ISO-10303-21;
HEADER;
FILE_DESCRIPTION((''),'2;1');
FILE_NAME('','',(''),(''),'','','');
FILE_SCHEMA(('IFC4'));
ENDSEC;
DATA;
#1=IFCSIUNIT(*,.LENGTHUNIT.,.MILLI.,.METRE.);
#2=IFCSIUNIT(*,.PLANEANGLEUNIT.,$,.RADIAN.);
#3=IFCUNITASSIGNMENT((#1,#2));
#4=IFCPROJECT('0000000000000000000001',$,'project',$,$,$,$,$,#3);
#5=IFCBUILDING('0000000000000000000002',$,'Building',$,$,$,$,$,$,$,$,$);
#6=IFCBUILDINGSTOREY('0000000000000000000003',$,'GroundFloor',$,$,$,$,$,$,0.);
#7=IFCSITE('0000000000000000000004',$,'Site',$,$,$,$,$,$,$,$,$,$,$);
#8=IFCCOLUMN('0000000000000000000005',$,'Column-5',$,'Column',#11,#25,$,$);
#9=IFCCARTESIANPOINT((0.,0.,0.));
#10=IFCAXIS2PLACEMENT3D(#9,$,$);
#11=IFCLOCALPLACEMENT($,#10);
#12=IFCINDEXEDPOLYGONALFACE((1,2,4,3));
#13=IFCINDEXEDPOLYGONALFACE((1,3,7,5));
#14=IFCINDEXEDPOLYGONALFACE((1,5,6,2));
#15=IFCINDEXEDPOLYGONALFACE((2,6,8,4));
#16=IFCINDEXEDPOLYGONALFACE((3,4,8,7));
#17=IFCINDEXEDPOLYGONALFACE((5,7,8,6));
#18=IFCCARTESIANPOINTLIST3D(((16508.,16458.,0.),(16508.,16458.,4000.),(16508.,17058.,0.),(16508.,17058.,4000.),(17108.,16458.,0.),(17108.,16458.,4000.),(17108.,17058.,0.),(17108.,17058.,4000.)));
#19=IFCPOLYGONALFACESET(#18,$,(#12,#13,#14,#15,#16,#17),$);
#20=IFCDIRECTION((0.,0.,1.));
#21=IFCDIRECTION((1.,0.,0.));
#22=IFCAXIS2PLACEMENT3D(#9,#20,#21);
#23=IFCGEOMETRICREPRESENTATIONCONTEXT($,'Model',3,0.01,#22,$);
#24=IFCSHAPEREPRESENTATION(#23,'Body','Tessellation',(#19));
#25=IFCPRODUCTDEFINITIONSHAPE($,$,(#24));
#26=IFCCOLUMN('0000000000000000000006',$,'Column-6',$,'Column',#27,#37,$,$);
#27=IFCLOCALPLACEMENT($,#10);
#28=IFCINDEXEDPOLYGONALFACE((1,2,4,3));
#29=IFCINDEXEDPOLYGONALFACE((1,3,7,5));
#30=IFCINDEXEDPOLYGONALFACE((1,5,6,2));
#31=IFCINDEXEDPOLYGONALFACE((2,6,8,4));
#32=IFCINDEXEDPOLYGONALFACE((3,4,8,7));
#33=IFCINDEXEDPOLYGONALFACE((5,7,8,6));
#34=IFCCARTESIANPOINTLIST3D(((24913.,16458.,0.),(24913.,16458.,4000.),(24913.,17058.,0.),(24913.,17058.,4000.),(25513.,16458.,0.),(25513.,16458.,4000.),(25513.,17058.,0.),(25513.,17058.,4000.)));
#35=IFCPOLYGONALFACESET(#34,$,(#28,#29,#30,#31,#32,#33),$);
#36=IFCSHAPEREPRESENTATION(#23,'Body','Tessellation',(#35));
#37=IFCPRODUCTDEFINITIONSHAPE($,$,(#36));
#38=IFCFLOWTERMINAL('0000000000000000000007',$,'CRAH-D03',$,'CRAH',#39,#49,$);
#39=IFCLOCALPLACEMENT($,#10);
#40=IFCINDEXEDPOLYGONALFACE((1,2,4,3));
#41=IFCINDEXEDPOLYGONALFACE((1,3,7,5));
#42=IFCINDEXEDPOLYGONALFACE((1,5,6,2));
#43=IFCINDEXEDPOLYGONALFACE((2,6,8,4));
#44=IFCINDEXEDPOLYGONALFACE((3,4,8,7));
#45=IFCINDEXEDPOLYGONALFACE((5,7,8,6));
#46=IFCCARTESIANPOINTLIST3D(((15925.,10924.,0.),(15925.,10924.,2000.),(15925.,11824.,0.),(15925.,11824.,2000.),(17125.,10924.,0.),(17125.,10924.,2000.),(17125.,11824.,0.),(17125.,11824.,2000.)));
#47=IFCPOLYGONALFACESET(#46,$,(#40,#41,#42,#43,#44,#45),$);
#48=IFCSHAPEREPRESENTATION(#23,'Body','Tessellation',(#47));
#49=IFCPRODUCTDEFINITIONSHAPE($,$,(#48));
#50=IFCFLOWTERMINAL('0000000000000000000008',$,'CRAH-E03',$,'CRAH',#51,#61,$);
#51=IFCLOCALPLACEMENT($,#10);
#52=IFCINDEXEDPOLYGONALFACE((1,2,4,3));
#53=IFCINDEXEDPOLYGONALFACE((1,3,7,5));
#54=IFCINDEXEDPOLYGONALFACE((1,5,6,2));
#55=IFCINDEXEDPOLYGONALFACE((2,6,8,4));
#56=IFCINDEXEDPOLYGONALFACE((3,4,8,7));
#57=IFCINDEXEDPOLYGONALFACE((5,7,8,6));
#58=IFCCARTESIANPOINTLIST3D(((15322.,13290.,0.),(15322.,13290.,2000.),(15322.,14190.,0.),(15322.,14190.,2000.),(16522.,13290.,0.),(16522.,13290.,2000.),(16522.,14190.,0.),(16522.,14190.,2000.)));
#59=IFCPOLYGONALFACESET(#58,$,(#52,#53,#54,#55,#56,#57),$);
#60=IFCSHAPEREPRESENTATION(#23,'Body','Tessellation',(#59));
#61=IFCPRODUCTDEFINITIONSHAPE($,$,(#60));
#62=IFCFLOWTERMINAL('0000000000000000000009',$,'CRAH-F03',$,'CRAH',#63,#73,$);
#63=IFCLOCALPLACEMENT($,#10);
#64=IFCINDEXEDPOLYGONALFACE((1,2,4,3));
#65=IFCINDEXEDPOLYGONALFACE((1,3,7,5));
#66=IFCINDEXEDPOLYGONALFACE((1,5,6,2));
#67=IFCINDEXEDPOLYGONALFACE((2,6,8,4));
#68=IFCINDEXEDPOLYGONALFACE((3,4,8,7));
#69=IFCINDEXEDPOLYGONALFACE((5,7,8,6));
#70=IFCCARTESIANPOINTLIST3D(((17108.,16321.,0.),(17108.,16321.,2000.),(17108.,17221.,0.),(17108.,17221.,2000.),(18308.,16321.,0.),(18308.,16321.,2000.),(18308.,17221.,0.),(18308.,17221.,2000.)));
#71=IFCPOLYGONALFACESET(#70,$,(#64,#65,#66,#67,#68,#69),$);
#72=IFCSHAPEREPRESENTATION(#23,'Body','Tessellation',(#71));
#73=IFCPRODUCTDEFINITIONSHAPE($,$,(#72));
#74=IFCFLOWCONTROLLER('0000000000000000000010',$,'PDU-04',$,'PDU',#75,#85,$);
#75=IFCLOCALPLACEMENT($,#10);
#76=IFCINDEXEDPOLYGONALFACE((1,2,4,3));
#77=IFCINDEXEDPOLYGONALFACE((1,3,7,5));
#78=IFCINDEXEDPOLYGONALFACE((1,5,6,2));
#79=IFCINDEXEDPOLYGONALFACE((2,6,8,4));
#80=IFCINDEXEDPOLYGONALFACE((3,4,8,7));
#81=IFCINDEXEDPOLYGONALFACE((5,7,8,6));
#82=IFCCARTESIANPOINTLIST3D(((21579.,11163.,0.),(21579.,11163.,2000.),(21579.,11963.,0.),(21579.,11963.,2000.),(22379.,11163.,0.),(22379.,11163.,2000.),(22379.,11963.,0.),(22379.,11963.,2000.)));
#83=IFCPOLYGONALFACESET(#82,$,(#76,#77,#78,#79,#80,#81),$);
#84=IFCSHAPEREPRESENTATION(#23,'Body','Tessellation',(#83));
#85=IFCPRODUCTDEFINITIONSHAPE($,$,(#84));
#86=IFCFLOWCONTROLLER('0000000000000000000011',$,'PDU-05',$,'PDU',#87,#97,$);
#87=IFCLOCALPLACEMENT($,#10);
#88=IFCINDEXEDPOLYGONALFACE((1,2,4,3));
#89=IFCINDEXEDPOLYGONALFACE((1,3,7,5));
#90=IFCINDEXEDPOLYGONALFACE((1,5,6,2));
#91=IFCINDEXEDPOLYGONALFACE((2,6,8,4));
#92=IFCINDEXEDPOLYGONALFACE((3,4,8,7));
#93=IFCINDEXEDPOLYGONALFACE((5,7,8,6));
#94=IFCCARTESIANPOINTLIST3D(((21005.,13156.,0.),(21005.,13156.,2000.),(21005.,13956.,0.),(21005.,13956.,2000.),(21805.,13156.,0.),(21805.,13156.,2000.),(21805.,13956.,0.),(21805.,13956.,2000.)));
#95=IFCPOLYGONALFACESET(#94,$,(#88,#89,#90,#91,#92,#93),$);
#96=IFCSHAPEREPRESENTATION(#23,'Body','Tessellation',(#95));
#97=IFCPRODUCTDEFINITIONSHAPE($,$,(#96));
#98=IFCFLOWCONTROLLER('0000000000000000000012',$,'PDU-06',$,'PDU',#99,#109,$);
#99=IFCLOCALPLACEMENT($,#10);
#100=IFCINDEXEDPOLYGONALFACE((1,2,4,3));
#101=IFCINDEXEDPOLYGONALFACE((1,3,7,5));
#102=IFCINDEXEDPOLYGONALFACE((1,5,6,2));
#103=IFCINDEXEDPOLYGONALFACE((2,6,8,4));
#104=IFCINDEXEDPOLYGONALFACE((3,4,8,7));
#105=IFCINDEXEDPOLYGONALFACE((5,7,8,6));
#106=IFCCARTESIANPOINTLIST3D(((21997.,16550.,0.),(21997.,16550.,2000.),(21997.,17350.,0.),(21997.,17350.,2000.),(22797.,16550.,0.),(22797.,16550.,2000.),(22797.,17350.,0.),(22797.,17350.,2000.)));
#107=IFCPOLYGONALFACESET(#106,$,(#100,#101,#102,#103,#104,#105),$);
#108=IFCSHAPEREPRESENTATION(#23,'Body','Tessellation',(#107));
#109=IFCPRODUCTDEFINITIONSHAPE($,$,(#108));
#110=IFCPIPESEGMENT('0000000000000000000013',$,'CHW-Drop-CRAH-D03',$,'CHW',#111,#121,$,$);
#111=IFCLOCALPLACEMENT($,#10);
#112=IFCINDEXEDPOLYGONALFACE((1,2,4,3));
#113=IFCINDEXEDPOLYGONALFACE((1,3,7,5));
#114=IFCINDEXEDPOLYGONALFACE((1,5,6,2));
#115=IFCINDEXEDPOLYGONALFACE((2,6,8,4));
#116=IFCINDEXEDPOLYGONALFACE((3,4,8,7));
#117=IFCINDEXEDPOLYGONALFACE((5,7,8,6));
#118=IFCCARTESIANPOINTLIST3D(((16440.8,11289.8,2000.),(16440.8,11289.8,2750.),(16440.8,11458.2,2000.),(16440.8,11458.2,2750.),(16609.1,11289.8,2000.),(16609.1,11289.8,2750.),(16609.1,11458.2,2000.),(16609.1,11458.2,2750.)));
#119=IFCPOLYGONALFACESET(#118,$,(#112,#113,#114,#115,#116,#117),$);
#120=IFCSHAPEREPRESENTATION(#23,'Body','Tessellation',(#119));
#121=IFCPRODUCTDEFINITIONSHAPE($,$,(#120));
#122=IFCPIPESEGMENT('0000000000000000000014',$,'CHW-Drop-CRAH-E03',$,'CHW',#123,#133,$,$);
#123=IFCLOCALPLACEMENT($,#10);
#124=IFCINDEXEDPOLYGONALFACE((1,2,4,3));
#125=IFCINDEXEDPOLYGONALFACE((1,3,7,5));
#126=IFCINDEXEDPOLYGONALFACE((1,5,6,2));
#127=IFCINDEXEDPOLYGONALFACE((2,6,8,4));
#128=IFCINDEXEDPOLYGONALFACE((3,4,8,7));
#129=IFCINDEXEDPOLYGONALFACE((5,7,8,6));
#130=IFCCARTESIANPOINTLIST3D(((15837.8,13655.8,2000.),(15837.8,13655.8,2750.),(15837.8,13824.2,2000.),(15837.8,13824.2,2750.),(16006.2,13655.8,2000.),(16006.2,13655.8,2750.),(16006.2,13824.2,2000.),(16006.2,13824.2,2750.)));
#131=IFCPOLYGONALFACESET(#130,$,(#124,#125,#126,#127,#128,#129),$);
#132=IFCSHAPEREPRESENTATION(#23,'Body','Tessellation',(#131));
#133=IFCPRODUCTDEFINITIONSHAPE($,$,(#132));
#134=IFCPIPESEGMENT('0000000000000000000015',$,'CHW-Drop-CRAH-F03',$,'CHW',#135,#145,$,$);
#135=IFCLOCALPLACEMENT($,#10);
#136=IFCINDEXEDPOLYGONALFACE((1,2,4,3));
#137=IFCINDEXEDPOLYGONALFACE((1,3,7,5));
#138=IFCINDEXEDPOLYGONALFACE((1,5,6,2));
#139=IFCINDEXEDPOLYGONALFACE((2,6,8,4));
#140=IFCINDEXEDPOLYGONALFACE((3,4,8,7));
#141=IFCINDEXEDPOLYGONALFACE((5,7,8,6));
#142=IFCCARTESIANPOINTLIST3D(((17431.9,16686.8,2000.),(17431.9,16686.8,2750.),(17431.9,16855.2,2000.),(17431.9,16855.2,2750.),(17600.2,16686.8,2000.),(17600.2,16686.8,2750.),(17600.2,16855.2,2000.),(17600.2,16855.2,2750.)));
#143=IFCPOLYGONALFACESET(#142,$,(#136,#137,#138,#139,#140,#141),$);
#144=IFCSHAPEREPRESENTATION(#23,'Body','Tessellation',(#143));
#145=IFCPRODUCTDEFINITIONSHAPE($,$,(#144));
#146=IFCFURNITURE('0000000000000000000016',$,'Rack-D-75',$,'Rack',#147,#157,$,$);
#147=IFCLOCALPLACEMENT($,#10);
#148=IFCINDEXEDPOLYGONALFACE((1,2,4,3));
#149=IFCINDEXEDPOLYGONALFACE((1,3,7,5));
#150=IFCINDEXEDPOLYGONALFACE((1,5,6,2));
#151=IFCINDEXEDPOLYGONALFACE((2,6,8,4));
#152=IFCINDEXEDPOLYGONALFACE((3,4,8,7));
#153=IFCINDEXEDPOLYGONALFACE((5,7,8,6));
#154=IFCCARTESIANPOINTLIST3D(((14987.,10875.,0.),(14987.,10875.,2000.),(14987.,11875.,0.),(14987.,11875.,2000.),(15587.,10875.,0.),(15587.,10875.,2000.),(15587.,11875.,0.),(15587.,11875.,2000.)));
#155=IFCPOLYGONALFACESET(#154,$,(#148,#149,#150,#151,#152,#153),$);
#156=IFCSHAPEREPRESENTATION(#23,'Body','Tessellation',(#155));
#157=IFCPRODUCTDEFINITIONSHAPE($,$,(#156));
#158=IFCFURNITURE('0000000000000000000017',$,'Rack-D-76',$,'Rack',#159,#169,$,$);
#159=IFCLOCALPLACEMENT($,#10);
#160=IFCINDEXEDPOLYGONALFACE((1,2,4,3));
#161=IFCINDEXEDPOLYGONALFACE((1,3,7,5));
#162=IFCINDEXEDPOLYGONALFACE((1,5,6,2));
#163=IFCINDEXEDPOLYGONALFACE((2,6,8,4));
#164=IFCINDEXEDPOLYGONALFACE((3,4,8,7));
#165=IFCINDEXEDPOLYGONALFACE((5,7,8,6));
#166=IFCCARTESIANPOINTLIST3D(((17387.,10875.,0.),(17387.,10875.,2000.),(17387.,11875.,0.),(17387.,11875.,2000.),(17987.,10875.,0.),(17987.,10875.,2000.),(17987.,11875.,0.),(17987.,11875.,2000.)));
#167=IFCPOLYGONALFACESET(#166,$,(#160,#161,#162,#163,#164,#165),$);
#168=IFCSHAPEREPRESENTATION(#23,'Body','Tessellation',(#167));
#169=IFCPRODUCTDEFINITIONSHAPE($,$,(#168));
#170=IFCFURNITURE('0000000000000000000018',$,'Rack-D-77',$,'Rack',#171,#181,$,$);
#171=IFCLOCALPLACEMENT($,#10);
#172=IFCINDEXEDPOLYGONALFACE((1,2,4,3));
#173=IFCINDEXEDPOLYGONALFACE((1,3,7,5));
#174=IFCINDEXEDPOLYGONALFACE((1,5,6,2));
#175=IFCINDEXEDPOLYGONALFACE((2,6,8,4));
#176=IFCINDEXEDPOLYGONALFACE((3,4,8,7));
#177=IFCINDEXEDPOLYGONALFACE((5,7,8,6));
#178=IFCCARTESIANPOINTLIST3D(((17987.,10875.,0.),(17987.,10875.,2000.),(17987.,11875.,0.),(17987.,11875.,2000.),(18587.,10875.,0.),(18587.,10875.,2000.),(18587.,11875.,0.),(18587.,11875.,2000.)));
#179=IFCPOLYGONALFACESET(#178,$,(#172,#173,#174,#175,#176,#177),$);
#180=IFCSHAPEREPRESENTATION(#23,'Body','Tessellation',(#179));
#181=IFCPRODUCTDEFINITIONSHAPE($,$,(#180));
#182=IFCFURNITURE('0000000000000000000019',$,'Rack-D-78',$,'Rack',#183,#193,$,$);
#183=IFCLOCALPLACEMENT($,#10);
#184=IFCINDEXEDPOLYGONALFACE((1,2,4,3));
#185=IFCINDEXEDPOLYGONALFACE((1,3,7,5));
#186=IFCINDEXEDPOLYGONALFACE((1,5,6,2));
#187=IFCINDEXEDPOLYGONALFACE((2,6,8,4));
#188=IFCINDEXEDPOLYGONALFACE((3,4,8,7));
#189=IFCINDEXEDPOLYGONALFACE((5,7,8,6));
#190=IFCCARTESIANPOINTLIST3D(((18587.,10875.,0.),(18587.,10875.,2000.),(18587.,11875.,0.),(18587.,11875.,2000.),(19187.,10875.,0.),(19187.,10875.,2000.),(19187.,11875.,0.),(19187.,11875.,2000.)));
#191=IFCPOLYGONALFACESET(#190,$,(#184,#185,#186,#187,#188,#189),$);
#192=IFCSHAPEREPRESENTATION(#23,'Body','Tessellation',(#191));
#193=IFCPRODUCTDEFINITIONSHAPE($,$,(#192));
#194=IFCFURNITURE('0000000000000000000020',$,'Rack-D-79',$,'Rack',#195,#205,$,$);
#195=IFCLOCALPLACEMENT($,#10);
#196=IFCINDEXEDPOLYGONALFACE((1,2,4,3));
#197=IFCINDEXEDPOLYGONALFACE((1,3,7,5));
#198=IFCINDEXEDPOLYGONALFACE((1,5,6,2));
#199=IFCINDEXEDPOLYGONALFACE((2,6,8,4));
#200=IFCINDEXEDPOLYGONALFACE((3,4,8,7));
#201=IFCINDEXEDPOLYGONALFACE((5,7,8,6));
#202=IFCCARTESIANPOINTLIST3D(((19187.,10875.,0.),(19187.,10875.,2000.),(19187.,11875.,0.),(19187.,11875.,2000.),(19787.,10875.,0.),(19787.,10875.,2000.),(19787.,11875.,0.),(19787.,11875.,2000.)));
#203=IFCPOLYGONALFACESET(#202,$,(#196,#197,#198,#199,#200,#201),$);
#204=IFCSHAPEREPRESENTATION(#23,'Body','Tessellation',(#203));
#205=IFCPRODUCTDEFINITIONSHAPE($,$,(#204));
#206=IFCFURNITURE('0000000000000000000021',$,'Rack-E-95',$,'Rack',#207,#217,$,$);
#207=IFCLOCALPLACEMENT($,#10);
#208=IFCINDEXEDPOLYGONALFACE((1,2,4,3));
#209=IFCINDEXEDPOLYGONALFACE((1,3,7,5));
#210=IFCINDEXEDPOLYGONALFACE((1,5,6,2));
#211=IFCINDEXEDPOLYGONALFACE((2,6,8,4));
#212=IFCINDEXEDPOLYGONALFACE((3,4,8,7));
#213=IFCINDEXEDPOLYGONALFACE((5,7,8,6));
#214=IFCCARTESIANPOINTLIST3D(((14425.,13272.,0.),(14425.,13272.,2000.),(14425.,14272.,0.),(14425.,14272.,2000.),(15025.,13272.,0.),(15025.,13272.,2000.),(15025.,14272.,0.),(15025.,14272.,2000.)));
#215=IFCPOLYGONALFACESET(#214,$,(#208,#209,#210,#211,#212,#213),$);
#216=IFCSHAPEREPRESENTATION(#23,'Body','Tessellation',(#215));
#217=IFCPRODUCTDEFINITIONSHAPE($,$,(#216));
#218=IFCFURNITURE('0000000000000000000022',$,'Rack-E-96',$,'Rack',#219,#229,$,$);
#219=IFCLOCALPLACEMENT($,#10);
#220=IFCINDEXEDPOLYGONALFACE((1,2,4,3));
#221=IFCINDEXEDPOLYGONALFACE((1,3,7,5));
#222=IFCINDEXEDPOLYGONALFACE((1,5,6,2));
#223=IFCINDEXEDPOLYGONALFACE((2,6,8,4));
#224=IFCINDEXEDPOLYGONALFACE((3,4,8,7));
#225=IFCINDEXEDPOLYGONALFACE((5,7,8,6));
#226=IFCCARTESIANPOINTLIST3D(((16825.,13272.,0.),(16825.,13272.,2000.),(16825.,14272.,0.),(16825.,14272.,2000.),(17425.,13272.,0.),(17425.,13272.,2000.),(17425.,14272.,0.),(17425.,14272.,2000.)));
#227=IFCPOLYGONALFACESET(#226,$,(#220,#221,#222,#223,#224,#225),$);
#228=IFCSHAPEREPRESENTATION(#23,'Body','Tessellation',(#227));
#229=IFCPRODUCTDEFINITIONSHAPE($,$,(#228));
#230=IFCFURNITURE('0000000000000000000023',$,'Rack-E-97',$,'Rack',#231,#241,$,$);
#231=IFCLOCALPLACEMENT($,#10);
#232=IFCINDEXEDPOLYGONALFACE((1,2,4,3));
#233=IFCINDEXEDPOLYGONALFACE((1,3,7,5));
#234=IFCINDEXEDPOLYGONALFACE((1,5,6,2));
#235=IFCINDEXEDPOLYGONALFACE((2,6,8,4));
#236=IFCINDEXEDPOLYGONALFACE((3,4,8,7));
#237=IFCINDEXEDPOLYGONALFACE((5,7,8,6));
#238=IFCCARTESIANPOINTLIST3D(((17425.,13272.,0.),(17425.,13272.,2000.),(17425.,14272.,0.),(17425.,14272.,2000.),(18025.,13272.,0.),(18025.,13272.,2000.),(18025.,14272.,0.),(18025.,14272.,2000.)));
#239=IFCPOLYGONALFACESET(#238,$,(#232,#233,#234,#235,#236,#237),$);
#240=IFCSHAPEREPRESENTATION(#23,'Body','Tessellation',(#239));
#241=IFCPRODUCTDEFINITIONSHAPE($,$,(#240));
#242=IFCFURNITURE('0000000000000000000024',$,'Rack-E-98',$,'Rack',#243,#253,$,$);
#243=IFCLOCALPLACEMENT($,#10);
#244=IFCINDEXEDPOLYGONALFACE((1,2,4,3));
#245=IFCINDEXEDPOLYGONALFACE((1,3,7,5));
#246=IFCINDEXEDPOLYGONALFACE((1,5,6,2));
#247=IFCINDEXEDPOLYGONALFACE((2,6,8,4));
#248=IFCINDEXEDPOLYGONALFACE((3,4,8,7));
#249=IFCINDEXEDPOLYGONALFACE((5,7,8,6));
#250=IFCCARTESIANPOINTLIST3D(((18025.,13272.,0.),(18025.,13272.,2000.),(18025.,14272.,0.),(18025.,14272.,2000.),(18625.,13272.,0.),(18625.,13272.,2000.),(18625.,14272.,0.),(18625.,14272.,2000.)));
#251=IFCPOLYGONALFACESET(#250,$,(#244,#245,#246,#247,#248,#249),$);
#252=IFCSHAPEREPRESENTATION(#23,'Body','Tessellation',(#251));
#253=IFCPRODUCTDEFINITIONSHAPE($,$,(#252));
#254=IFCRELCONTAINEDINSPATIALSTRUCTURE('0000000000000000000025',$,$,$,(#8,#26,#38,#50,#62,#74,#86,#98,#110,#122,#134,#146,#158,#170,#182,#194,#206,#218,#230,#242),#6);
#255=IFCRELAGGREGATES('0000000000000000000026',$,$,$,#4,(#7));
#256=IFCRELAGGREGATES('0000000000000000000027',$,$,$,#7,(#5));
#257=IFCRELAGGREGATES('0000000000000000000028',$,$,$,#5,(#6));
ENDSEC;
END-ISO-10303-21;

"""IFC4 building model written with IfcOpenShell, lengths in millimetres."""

from ifc_helpers import new_model, si_unit, frame, origin, origin_with_axes, origin_2d, place, context, project, spatial, rectangle, extrude, element, save


model = new_model("IFC4")

# Units and contexts
model_context = context("Model", 3, precision=0.01, world=origin_with_axes())
ifc_project = project(units=[si_unit("LENGTHUNIT", "METRE", prefix="MILLI"), si_unit("PLANEANGLEUNIT", "RADIAN")])

# Site, building, storey
site = spatial("IfcSite", under=ifc_project, Name="Site")
building = spatial("IfcBuilding", under=site, Name="Building")
storey = spatial("IfcBuildingStorey", under=building, Name="GroundFloor", Elevation=0.0)

# Columns
for number, where, z_axis, x_axis, name in (
    (1, (16808.0, 16758.0, 0.0), (0.0, 0.0, 1.0), (1.0, 0.0, 0.0), "Column-5"),
    (2, (25213.0, 16758.0, 0.0), (0.0, 0.0, 1.0), (1.0, 0.0, 0.0), "Column-6"),
):
    element("IfcColumn", number, at=place(None, frame(where, z_axis=z_axis, x_axis=x_axis)), inside=storey, Name=name, ObjectType="Column", context=model_context, shape_type="SweptSolid", body=[
        extrude(rectangle(XDim=600.0, YDim=600.0, at=origin_2d()), origin(), (0.0, 0.0, 1.0), 4000.0),
    ])

# Flow terminals
for number, where, z_axis, x_axis, name in (
    (3, (16525.0, 11374.0, 0.0), (0.0, 0.0, 1.0), (1.0, 0.0, 0.0), "CRAH-D03"),
    (4, (15922.0, 13740.0, 0.0), (0.0, 0.0, 1.0), (1.0, 0.0, 0.0), "CRAH-E03"),
    (5, (17708.0, 16771.0, 0.0), (0.0, 0.0, 1.0), (1.0, 0.0, 0.0), "CRAH-F03"),
):
    element("IfcFlowTerminal", number, at=place(None, frame(where, z_axis=z_axis, x_axis=x_axis)), inside=storey, Name=name, ObjectType="CRAH", context=model_context, shape_type="SweptSolid", body=[
        extrude(rectangle(XDim=1200.0, YDim=900.0, at=origin_2d()), origin(), (0.0, 0.0, 1.0), 2000.0),
    ])

# Flow controllers
for number, where, z_axis, x_axis, name in (
    (6, (21979.0, 11563.0, 0.0), (0.0, 0.0, 1.0), (1.0, 0.0, 0.0), "PDU-04"),
    (7, (21405.0, 13556.0, 0.0), (0.0, 0.0, 1.0), (1.0, 0.0, 0.0), "PDU-05"),
    (8, (22397.0, 16950.0, 0.0), (0.0, 0.0, 1.0), (1.0, 0.0, 0.0), "PDU-06"),
):
    element("IfcFlowController", number, at=place(None, frame(where, z_axis=z_axis, x_axis=x_axis)), inside=storey, Name=name, ObjectType="PDU", context=model_context, shape_type="SweptSolid", body=[
        extrude(rectangle(XDim=800.0, YDim=800.0, at=origin_2d()), origin(), (0.0, 0.0, 1.0), 2000.0),
    ])

# Pipe segments
for number, where, z_axis, x_axis, name in (
    (9, (16525.0, 11374.0, 2000.0), (0.0, 0.0, 1.0), (1.0, 0.0, 0.0), "CHW-Drop-CRAH-D03"),
    (10, (15922.0, 13740.0, 2000.0), (0.0, 0.0, 1.0), (1.0, 0.0, 0.0), "CHW-Drop-CRAH-E03"),
    (11, (17516.0, 16771.0, 2000.0), (0.0, 0.0, 1.0), (1.0, 0.0, 0.0), "CHW-Drop-CRAH-F03"),
):
    element("IfcPipeSegment", number, at=place(None, frame(where, z_axis=z_axis, x_axis=x_axis)), inside=storey, Name=name, ObjectType="CHW", context=model_context, shape_type="SweptSolid", body=[
        extrude(rectangle(XDim=168.3, YDim=168.3, at=origin_2d()), origin(), (0.0, 0.0, 1.0), 750.0),
    ])

# Furniture
for number, where, z_axis, x_axis, name in (
    (12, (15287.0, 11375.0, 0.0), (0.0, 0.0, 1.0), (1.0, 0.0, 0.0), "Rack-D-75"),
    (13, (17687.0, 11375.0, 0.0), (0.0, 0.0, 1.0), (1.0, 0.0, 0.0), "Rack-D-76"),
    (14, (18287.0, 11375.0, 0.0), (0.0, 0.0, 1.0), (1.0, 0.0, 0.0), "Rack-D-77"),
    (15, (18887.0, 11375.0, 0.0), (0.0, 0.0, 1.0), (1.0, 0.0, 0.0), "Rack-D-78"),
    (16, (19487.0, 11375.0, 0.0), (0.0, 0.0, 1.0), (1.0, 0.0, 0.0), "Rack-D-79"),
    (17, (14725.0, 13772.0, 0.0), (0.0, 0.0, 1.0), (1.0, 0.0, 0.0), "Rack-E-95"),
    (18, (17125.0, 13772.0, 0.0), (0.0, 0.0, 1.0), (1.0, 0.0, 0.0), "Rack-E-96"),
    (19, (17725.0, 13772.0, 0.0), (0.0, 0.0, 1.0), (1.0, 0.0, 0.0), "Rack-E-97"),
    (20, (18325.0, 13772.0, 0.0), (0.0, 0.0, 1.0), (1.0, 0.0, 0.0), "Rack-E-98"),
):
    element("IfcFurniture", number, at=place(None, frame(where, z_axis=z_axis, x_axis=x_axis)), inside=storey, Name=name, ObjectType="Rack", context=model_context, shape_type="SweptSolid", body=[
        extrude(rectangle(XDim=600.0, YDim=1000.0, at=origin_2d()), origin(), (0.0, 0.0, 1.0), 2000.0),
    ])

save(model, "model.ifc")
